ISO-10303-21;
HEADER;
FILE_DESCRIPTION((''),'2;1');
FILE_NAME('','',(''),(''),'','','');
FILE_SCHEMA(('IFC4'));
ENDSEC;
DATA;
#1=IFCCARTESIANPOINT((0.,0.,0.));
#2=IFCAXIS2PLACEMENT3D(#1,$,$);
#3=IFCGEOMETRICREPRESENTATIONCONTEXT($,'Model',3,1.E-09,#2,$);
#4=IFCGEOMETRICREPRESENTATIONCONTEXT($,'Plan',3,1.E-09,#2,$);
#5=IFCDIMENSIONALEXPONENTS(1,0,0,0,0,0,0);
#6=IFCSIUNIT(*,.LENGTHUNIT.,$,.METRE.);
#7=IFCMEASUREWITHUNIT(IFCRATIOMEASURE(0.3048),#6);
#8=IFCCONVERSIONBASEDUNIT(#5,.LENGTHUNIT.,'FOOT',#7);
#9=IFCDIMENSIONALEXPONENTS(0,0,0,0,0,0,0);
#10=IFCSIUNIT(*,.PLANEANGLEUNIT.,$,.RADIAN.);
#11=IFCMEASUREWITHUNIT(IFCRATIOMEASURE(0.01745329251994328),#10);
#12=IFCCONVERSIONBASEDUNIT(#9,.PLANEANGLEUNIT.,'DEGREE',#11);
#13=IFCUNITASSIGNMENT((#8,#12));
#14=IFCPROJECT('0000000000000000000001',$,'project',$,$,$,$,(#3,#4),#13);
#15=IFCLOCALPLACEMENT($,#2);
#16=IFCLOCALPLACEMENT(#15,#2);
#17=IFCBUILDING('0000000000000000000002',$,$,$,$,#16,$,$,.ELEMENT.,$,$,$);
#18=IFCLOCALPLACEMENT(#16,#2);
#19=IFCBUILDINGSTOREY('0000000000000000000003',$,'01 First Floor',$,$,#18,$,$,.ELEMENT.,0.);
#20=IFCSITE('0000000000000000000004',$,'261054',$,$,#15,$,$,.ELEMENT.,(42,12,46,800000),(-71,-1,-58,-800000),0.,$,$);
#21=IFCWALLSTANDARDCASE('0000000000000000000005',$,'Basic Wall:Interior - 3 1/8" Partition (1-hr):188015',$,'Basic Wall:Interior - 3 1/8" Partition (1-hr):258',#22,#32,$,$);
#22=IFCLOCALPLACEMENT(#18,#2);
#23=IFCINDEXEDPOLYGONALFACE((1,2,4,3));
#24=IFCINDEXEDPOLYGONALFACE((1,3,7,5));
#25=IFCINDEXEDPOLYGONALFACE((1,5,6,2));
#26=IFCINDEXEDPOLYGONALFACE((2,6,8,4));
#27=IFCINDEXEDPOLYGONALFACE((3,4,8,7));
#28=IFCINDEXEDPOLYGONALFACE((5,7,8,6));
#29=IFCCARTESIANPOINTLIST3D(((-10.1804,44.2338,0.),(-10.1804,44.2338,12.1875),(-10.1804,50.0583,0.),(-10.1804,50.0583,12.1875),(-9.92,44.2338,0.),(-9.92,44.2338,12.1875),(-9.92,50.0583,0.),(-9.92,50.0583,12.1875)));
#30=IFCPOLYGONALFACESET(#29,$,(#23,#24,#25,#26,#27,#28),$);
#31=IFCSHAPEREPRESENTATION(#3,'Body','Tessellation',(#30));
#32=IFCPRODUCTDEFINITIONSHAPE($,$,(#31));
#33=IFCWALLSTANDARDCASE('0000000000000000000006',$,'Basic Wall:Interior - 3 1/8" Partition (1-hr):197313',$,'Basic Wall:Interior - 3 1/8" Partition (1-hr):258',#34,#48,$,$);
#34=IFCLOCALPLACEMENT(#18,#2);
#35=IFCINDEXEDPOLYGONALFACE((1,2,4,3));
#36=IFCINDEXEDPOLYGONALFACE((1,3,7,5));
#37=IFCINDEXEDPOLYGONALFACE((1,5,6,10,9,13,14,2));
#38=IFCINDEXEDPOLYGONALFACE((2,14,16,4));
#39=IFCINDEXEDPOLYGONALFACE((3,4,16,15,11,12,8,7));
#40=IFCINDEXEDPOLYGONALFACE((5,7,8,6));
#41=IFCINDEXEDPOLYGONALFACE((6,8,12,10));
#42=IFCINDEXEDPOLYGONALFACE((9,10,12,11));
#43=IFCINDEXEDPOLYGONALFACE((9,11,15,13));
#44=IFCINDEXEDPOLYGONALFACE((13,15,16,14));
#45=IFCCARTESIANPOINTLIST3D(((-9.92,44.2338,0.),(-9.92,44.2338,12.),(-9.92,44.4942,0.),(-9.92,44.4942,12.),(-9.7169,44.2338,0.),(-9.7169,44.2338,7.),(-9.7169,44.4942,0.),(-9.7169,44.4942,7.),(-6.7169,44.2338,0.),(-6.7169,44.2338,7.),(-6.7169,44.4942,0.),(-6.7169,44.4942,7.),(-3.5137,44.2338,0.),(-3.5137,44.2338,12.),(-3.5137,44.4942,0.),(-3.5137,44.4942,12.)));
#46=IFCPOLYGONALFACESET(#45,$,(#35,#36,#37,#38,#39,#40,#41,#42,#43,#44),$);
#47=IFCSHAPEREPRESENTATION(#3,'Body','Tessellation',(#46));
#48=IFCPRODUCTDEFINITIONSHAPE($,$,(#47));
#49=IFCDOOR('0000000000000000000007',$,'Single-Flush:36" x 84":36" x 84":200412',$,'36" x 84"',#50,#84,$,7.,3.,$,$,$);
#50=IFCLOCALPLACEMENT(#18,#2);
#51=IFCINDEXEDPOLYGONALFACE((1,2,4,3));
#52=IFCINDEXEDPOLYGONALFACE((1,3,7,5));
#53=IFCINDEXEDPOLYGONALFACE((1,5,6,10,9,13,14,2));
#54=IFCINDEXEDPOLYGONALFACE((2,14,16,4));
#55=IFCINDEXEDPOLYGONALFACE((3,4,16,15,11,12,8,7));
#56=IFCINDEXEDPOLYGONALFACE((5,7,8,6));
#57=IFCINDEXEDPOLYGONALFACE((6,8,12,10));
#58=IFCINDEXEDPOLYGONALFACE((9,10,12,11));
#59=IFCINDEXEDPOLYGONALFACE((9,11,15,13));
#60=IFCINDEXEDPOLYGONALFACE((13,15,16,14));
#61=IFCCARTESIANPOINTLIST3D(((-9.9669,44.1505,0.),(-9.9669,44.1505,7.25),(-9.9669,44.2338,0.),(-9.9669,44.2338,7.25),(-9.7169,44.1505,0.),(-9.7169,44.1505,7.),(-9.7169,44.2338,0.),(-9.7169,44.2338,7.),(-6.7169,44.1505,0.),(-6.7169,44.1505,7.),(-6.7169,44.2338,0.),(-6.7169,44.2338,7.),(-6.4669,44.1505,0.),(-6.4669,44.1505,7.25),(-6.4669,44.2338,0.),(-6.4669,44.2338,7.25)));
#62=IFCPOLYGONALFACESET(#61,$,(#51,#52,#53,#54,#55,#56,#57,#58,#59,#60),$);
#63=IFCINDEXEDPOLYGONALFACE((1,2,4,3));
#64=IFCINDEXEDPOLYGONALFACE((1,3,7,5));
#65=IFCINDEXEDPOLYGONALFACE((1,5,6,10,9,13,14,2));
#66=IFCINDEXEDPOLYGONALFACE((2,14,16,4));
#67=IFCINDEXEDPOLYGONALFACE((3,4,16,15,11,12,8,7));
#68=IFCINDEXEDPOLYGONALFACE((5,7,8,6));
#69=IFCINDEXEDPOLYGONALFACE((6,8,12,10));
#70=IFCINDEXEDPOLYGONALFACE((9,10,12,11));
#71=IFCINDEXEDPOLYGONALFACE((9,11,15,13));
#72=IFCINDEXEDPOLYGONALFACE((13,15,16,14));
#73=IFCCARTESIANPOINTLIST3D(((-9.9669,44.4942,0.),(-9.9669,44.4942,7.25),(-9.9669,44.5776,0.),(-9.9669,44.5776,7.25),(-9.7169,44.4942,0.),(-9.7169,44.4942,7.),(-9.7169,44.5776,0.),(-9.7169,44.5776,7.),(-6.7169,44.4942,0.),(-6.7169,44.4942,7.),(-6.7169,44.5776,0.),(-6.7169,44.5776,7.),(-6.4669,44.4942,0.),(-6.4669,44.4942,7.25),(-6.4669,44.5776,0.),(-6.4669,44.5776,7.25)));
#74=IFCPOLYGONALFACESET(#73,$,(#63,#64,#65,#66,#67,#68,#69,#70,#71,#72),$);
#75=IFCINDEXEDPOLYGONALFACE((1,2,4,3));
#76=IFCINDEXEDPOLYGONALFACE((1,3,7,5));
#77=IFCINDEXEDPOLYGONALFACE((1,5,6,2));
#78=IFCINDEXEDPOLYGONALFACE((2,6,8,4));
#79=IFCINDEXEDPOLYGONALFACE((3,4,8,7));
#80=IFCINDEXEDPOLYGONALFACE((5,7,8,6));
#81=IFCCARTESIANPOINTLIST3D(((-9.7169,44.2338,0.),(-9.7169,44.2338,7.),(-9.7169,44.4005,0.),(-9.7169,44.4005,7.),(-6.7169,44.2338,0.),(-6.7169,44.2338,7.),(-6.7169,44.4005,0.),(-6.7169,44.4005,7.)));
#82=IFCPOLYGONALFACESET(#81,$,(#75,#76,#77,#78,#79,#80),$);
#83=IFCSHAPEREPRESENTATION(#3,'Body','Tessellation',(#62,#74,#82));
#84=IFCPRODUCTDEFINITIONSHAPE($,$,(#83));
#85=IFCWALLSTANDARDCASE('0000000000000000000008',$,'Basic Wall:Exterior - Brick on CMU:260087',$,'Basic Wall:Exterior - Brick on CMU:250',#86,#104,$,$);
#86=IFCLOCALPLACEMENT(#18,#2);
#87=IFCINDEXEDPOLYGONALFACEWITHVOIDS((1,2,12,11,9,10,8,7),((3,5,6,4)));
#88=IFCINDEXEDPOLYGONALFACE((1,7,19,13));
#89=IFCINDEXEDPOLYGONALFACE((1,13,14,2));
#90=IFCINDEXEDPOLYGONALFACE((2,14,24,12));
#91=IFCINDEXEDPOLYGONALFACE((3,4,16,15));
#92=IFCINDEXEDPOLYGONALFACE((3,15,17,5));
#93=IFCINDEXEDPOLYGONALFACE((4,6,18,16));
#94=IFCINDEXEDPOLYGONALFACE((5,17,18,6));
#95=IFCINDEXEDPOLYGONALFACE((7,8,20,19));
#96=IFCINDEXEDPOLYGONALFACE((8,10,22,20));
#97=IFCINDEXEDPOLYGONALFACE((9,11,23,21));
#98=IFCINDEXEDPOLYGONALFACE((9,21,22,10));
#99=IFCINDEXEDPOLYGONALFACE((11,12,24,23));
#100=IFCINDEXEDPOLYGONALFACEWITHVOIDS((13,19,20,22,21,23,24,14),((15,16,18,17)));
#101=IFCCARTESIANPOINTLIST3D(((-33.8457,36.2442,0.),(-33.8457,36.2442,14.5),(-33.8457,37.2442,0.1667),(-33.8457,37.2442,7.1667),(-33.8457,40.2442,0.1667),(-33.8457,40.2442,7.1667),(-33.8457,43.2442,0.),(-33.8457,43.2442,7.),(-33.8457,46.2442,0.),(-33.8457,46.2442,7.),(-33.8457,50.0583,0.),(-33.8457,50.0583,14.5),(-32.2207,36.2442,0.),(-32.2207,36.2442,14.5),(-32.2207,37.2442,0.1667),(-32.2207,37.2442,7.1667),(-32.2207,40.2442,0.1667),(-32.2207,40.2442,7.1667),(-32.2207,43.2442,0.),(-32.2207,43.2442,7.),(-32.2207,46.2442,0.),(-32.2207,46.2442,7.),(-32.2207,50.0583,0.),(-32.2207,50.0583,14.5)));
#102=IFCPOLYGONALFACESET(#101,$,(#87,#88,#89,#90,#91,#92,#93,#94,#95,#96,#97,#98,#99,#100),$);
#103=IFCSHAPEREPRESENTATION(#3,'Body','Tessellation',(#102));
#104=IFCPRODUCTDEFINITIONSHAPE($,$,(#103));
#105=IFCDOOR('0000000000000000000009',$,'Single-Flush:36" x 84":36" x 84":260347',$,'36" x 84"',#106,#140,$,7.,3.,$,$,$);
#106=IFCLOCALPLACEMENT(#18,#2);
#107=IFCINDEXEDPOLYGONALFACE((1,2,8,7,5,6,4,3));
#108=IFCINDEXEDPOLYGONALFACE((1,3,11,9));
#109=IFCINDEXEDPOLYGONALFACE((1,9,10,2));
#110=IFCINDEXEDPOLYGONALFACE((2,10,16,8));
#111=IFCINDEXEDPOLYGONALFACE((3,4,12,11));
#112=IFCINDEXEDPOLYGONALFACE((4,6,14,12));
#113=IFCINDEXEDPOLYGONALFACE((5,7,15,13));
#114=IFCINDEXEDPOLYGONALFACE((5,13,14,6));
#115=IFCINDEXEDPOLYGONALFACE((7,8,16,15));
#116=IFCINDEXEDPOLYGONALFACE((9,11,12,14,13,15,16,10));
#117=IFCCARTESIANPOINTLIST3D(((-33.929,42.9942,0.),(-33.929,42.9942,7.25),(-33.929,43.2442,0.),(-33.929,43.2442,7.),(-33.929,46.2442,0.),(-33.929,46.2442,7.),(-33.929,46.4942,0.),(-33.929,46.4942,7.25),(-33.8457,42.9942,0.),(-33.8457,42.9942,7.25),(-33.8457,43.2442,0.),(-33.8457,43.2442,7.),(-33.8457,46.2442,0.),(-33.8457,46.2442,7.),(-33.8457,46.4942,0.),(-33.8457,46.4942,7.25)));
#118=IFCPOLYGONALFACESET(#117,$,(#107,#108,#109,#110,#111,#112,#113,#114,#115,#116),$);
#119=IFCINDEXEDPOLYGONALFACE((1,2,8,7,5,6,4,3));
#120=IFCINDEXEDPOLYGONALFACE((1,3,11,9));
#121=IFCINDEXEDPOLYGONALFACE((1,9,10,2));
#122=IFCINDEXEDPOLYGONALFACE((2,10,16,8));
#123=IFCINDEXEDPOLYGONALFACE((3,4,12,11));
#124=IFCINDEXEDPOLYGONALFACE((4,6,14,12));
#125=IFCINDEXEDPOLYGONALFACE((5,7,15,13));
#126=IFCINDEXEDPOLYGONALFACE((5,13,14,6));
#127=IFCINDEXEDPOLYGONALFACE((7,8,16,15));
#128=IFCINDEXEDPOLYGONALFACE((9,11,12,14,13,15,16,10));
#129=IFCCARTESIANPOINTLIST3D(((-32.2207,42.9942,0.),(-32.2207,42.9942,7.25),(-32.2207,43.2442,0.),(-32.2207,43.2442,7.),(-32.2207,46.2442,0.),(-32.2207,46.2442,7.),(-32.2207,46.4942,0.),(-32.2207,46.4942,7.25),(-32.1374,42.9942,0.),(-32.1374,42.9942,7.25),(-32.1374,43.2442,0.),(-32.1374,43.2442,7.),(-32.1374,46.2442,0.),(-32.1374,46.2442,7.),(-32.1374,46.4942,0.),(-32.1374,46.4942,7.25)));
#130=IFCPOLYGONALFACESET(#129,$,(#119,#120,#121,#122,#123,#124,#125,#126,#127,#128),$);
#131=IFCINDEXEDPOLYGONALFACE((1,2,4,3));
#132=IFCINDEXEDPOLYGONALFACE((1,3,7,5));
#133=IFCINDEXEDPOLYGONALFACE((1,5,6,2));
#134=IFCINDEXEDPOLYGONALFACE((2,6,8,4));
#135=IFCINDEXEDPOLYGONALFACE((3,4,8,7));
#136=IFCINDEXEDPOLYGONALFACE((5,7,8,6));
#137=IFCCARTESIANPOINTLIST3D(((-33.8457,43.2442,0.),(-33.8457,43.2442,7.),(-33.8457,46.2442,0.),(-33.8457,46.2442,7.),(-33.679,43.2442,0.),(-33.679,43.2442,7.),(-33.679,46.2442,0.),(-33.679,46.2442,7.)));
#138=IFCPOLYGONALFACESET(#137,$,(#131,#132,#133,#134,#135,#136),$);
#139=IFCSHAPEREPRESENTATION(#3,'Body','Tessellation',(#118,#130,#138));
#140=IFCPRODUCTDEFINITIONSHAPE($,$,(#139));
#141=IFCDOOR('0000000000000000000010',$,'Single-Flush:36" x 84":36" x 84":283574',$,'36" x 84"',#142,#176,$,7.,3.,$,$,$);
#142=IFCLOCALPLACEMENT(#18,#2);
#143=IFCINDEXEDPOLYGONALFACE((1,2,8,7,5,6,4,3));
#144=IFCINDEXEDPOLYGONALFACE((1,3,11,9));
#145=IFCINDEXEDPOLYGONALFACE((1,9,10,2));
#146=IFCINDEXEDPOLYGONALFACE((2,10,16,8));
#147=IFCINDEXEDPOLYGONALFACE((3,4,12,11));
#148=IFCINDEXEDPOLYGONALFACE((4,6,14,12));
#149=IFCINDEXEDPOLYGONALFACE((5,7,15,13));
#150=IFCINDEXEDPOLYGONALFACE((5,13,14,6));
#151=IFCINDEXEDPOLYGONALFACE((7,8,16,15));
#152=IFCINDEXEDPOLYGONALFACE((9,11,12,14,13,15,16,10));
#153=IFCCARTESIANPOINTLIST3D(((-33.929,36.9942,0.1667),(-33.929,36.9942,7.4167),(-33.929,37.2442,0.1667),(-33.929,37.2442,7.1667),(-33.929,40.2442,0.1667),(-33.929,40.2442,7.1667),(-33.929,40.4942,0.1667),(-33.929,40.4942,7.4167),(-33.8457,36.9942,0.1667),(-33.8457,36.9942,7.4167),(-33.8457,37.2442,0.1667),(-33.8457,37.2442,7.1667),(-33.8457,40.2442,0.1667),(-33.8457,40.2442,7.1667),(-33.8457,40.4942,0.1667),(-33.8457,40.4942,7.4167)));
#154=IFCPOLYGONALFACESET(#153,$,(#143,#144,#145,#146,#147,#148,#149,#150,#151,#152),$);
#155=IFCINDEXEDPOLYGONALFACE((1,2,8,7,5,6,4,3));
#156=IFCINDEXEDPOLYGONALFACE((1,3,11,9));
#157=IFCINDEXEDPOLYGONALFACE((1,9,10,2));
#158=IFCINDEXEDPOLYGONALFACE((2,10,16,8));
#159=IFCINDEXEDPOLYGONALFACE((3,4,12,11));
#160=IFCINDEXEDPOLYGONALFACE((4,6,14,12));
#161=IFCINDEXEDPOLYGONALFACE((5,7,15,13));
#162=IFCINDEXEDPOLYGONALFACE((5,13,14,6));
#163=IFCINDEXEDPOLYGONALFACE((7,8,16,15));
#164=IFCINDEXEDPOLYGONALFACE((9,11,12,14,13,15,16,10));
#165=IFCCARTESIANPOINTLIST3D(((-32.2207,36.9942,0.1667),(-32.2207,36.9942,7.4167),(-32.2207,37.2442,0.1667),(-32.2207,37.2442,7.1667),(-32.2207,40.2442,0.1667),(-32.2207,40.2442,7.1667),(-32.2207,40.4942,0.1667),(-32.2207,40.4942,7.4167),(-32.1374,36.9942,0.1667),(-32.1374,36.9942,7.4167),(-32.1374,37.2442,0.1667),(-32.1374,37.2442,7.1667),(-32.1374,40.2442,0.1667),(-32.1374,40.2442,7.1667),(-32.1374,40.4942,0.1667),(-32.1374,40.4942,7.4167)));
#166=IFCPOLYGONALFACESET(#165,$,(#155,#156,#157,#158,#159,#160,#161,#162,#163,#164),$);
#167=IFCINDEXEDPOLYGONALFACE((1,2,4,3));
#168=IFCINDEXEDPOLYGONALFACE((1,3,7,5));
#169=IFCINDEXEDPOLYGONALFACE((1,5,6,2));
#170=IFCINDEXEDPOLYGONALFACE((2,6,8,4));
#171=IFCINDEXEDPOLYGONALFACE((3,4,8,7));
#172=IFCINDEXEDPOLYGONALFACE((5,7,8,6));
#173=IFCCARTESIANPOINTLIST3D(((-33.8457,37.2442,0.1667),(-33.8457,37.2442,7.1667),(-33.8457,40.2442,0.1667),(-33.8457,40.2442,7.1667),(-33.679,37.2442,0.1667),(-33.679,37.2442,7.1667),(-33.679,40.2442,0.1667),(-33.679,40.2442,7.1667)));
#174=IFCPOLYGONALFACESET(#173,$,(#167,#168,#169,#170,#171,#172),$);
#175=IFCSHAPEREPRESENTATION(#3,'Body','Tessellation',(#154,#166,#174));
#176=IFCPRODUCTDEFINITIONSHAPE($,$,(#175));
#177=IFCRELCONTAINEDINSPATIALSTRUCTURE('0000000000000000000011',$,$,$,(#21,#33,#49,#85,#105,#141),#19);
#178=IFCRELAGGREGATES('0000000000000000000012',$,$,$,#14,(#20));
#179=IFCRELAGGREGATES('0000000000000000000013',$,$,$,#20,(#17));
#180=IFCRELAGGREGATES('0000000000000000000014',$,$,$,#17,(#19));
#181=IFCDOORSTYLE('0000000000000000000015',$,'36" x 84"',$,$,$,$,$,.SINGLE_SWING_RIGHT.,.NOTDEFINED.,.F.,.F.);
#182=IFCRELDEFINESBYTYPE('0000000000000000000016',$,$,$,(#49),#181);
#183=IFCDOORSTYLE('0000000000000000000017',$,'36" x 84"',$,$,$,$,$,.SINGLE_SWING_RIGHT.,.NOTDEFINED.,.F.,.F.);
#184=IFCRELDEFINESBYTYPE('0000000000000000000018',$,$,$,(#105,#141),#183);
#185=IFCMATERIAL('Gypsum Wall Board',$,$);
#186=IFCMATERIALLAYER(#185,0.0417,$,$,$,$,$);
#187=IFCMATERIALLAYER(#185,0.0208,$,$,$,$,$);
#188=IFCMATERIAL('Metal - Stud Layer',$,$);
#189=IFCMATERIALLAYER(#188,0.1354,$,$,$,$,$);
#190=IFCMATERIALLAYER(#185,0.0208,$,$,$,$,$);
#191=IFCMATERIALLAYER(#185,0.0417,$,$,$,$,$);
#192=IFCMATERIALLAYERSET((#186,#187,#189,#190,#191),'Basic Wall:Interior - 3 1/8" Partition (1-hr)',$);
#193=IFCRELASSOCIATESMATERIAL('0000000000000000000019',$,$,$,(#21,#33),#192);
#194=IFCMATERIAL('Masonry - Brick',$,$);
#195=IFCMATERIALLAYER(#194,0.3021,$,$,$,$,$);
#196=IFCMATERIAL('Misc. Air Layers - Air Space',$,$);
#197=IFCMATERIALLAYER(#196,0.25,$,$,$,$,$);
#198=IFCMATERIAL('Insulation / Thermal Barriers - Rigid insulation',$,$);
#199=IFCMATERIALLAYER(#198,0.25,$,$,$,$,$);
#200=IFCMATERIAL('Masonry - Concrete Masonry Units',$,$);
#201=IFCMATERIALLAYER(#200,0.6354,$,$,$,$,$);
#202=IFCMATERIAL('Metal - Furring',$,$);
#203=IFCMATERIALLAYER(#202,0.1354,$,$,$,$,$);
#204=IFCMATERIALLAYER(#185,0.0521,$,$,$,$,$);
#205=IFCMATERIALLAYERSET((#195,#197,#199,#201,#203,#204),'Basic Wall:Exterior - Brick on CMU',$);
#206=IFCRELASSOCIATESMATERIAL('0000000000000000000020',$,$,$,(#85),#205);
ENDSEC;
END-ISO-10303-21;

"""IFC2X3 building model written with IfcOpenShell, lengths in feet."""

from ifc_helpers import new_model, entity, si_unit, converted_unit, frame, frame_2d, origin, origin_2d_with_axis, place, context, project, spatial, polyline, rectangle, outline, extrude, clip, bounded_halfspace, source, transform, mapped, material, layer, layer_set, layer_usage, type_object, type_shapes, element, fill, save


model = new_model("IFC2X3")

# Units and contexts
model_context = context("Model", 3, precision=1e-09, world=origin())
plan_context = context("Plan", 3, precision=1e-09, world=origin())
ifc_project = project(units=[converted_unit("LENGTHUNIT", "FOOT", entity("IfcRatioMeasure", 0.3048), si_unit("LENGTHUNIT", "METRE"), dimensions=[1, 0, 0, 0, 0, 0, 0]), converted_unit("PLANEANGLEUNIT", "DEGREE", entity("IfcRatioMeasure", 0.01745329251994328), si_unit("PLANEANGLEUNIT", "RADIAN"), dimensions=[0, 0, 0, 0, 0, 0, 0])], contexts=[model_context, plan_context])

# Site, building, storey
site_placement = place(None, origin())
site = spatial("IfcSite", under=ifc_project, at=site_placement, Name="261054", CompositionType="ELEMENT", RefLatitude=(42, 12, 46, 800000), RefLongitude=(-71, -1, -58, -800000), RefElevation=0.0)
building_placement = place(site_placement, origin())
building = spatial("IfcBuilding", under=site, at=building_placement, CompositionType="ELEMENT")
storey_placement = place(building_placement, origin())
storey = spatial("IfcBuildingStorey", under=building, at=storey_placement, Name="01 First Floor", CompositionType="ELEMENT", Elevation=0.0)

# Wall
ifc_material_1 = material(Name="Gypsum Wall Board")
ifc_layer_1 = layer(ifc_material_1, 0.0417)
ifc_layer_2 = layer(ifc_material_1, 0.0208)
ifc_material_2 = material(Name="Metal - Stud Layer")
ifc_layer_3 = layer(ifc_material_2, 0.1354)
ifc_layer_4 = layer(ifc_material_1, 0.0208)
ifc_layer_5 = layer(ifc_material_1, 0.0417)
ifc_layer_set_1 = layer_set([ifc_layer_1, ifc_layer_2, ifc_layer_3, ifc_layer_4, ifc_layer_5], Name="Basic Wall:Interior - 3 1/8\" Partition (1-hr)")
ifc_layer_usage_1 = layer_usage(ifc_layer_set_1, "AXIS2", "NEGATIVE", 0.1302)
wall_1_placement = place(storey_placement, frame((-10.0502, 44.2338, 0.0), z_axis=(0.0, 0.0, 1.0), x_axis=(0.0, 1.0, 0.0)))
element("IfcWallStandardCase", 1, at=wall_1_placement, inside=storey, material=ifc_layer_usage_1, Name="Basic Wall:Interior - 3 1/8\" Partition (1-hr):188015", ObjectType="Basic Wall:Interior - 3 1/8\" Partition (1-hr):258", context=model_context, shape_type="SweptSolid", body=[
    extrude(rectangle(XDim=5.8245, YDim=0.2604, at=frame_2d((2.9122, 0.0), x_axis=(-1.0, 0.0))), origin(), (0.0, 0.0, 1.0), 12.1875),
])

# Wall, opening, door
ifc_layer_usage_2 = layer_usage(ifc_layer_set_1, "AXIS2", "NEGATIVE", 0.1302)
wall_2_placement = place(storey_placement, frame((-9.92, 44.364, 0.0)))
wall_2 = element("IfcWallStandardCase", 2, at=wall_2_placement, inside=storey, material=ifc_layer_usage_2, Name="Basic Wall:Interior - 3 1/8\" Partition (1-hr):197313", ObjectType="Basic Wall:Interior - 3 1/8\" Partition (1-hr):258", context=model_context, shape_type="SweptSolid", body=[
    extrude(rectangle(XDim=6.4063, YDim=0.2604, at=frame_2d((3.2031, 0.0), x_axis=(-1.0, 0.0))), origin(), (0.0, 0.0, 1.0), 12.0),
])
opening_1_placement = place(wall_2_placement, frame((3.2031, 0.1302, 0.0)))
opening_1 = element("IfcOpeningElement", 3, at=opening_1_placement, cuts=wall_2, ObjectType="Opening", context=model_context, shape_type="SweptSolid", body=[
    extrude(rectangle(XDim=3.0, YDim=7.0, at=frame_2d((3.5, 1.5), x_axis=(0.0, 1.0))), frame((0.0, 0.0, 0.0), z_axis=(0.0, -1.0, 0.0), x_axis=(0.0, 0.0, 1.0)), (0.0, 0.0, 1.0), 0.2604),
])
door_style_1 = type_object("IfcDoorStyle", Name="36\" x 84\"", ConstructionType="NOTDEFINED", OperationType="SINGLE_SWING_RIGHT", ParameterTakesPrecedence=False, Sizeable=False)
shared_shape_1 = source(origin(), model_context, "Body", "SweptSolid", [
    extrude(outline(polyline([(-1.75, -3.6875), (1.75, -3.6875), (1.75, 3.5625), (1.5, 3.5625), (1.5, -3.4375), (-1.5, -3.4375), (-1.5, 3.5625), (-1.75, 3.5625), (-1.75, -3.6875)])), frame((1.5, 0.2604, 3.5625), z_axis=(0.0, 1.0, 0.0), x_axis=(1.0, 0.0, 0.0)), (0.0, 0.0, 1.0), 0.0833),
    extrude(outline(polyline([(-3.6875, -1.75), (3.5625, -1.75), (3.5625, -1.5), (-3.4375, -1.5), (-3.4375, 1.5), (3.5625, 1.5), (3.5625, 1.75), (-3.6875, 1.75), (-3.6875, -1.75)])), frame((1.5, -0.0833, 3.5625), z_axis=(0.0, 1.0, 0.0), x_axis=(0.0, 0.0, -1.0)), (0.0, 0.0, 1.0), 0.0833),
    extrude(rectangle(XDim=0.1667, YDim=3.0, at=origin_2d_with_axis()), frame((1.5, 0.1771, 0.0), z_axis=(0.0, 0.0, 1.0), x_axis=(0.0, 1.0, 0.0)), (0.0, 0.0, 1.0), 7.0),
])
type_shapes(door_style_1, [shared_shape_1])
door_1_placement = place(opening_1_placement, frame((0.0, 0.0, 0.0), z_axis=(0.0, 0.0, 1.0), x_axis=(-1.0, 0.0, 0.0)))
door_1 = element("IfcDoor", 4, at=door_1_placement, inside=storey, type_object=door_style_1, Name="Single-Flush:36\" x 84\":36\" x 84\":200412", ObjectType="36\" x 84\"", OverallHeight=7.0, OverallWidth=3.0, context=model_context, shape_type="MappedRepresentation", body=[
    mapped(shared_shape_1, transform((0.0, 0.0, 0.0), scale=1.0)),
])
fill(opening_1, door_1)

# Wall, openings, doors
ifc_material_3 = material(Name="Masonry - Brick")
ifc_layer_6 = layer(ifc_material_3, 0.3021)
ifc_material_4 = material(Name="Misc. Air Layers - Air Space")
ifc_layer_7 = layer(ifc_material_4, 0.25)
ifc_material_5 = material(Name="Insulation / Thermal Barriers - Rigid insulation")
ifc_layer_8 = layer(ifc_material_5, 0.25)
ifc_material_6 = material(Name="Masonry - Concrete Masonry Units")
ifc_layer_9 = layer(ifc_material_6, 0.6354)
ifc_material_7 = material(Name="Metal - Furring")
ifc_layer_10 = layer(ifc_material_7, 0.1354)
ifc_layer_11 = layer(ifc_material_1, 0.0521)
ifc_layer_set_2 = layer_set([ifc_layer_6, ifc_layer_7, ifc_layer_8, ifc_layer_9, ifc_layer_10, ifc_layer_11], Name="Basic Wall:Exterior - Brick on CMU")
ifc_layer_usage_3 = layer_usage(ifc_layer_set_2, "AXIS2", "NEGATIVE", 0.8125)
wall_3_placement = place(storey_placement, frame((-33.0332, 36.2442, 0.0), z_axis=(0.0, 0.0, 1.0), x_axis=(0.0, 1.0, 0.0)))
wall_3 = element("IfcWallStandardCase", 5, at=wall_3_placement, inside=storey, material=ifc_layer_usage_3, Name="Basic Wall:Exterior - Brick on CMU:260087", ObjectType="Basic Wall:Exterior - Brick on CMU:250", context=model_context, shape_type="Clipping", body=[
    clip(extrude(rectangle(XDim=13.814, YDim=1.625, at=frame_2d((6.907, 0.0), x_axis=(-1.0, 0.0))), origin(), (0.0, 0.0, 1.0), 15.5), bounded_halfspace(frame((0.0, -0.8125, 14.5), z_axis=(0.0, 0.0, -1.0), x_axis=(0.0, -1.0, 0.0)), True, frame((0.0, -0.8125, 14.5), z_axis=(0.0, 0.0, -1.0), x_axis=(0.0, -1.0, 0.0)), polyline([(0.0, 0.0), (-1.625, 0.0), (-1.625, -13.814), (0.0, -13.814), (0.0, 0.0)]))),
])
opening_2_placement = place(wall_3_placement, frame((7.0, -0.8125, 0.0)))
opening_2 = element("IfcOpeningElement", 6, at=opening_2_placement, cuts=wall_3, ObjectType="Opening", context=model_context, shape_type="SweptSolid", body=[
    extrude(rectangle(XDim=3.0, YDim=7.0, at=frame_2d((3.5, 1.5), x_axis=(0.0, 1.0))), frame((0.0, 0.0, 0.0), z_axis=(0.0, 1.0, 0.0), x_axis=(0.0, 0.0, 1.0)), (0.0, 0.0, 1.0), 1.625),
])
opening_3_placement = place(wall_3_placement, frame((1.0, -0.8125, 0.1667)))
opening_3 = element("IfcOpeningElement", 7, at=opening_3_placement, cuts=wall_3, ObjectType="Opening", context=model_context, shape_type="SweptSolid", body=[
    extrude(rectangle(XDim=3.0, YDim=7.0, at=frame_2d((3.5, 1.5), x_axis=(0.0, 1.0))), frame((0.0, 0.0, 0.0), z_axis=(0.0, 1.0, 0.0), x_axis=(0.0, 0.0, 1.0)), (0.0, 0.0, 1.0), 1.625),
])
door_style_2 = type_object("IfcDoorStyle", Name="36\" x 84\"", ConstructionType="NOTDEFINED", OperationType="SINGLE_SWING_RIGHT", ParameterTakesPrecedence=False, Sizeable=False)
shared_shape_2 = source(origin(), model_context, "Body", "SweptSolid", [
    extrude(outline(polyline([(-1.75, -3.6875), (1.75, -3.6875), (1.75, 3.5625), (1.5, 3.5625), (1.5, -3.4375), (-1.5, -3.4375), (-1.5, 3.5625), (-1.75, 3.5625), (-1.75, -3.6875)])), frame((1.5, 1.625, 3.5625), z_axis=(0.0, 1.0, 0.0), x_axis=(1.0, 0.0, 0.0)), (0.0, 0.0, 1.0), 0.0833),
    extrude(outline(polyline([(-3.6875, -1.75), (3.5625, -1.75), (3.5625, -1.5), (-3.4375, -1.5), (-3.4375, 1.5), (3.5625, 1.5), (3.5625, 1.75), (-3.6875, 1.75), (-3.6875, -1.75)])), frame((1.5, -0.0833, 3.5625), z_axis=(0.0, 1.0, 0.0), x_axis=(0.0, 0.0, -1.0)), (0.0, 0.0, 1.0), 0.0833),
    extrude(rectangle(XDim=0.1667, YDim=3.0, at=origin_2d_with_axis()), frame((1.5, 1.5417, 0.0), z_axis=(0.0, 0.0, 1.0), x_axis=(0.0, 1.0, 0.0)), (0.0, 0.0, 1.0), 7.0),
])
type_shapes(door_style_2, [shared_shape_2])
door_2_placement = place(opening_2_placement, origin())
door_2 = element("IfcDoor", 8, at=door_2_placement, inside=storey, type_object=door_style_2, Name="Single-Flush:36\" x 84\":36\" x 84\":260347", ObjectType="36\" x 84\"", OverallHeight=7.0, OverallWidth=3.0, context=model_context, shape_type="MappedRepresentation", body=[
    mapped(shared_shape_2, transform((0.0, 0.0, 0.0), scale=1.0)),
])
fill(opening_2, door_2)
door_3_placement = place(opening_3_placement, origin())
door_3 = element("IfcDoor", 9, at=door_3_placement, inside=storey, type_object=door_style_2, Name="Single-Flush:36\" x 84\":36\" x 84\":283574", ObjectType="36\" x 84\"", OverallHeight=7.0, OverallWidth=3.0, context=model_context, shape_type="MappedRepresentation", body=[
    mapped(shared_shape_2, transform((0.0, 0.0, 0.0), scale=1.0)),
])
fill(opening_3, door_3)

save(model, "model.ifc")
